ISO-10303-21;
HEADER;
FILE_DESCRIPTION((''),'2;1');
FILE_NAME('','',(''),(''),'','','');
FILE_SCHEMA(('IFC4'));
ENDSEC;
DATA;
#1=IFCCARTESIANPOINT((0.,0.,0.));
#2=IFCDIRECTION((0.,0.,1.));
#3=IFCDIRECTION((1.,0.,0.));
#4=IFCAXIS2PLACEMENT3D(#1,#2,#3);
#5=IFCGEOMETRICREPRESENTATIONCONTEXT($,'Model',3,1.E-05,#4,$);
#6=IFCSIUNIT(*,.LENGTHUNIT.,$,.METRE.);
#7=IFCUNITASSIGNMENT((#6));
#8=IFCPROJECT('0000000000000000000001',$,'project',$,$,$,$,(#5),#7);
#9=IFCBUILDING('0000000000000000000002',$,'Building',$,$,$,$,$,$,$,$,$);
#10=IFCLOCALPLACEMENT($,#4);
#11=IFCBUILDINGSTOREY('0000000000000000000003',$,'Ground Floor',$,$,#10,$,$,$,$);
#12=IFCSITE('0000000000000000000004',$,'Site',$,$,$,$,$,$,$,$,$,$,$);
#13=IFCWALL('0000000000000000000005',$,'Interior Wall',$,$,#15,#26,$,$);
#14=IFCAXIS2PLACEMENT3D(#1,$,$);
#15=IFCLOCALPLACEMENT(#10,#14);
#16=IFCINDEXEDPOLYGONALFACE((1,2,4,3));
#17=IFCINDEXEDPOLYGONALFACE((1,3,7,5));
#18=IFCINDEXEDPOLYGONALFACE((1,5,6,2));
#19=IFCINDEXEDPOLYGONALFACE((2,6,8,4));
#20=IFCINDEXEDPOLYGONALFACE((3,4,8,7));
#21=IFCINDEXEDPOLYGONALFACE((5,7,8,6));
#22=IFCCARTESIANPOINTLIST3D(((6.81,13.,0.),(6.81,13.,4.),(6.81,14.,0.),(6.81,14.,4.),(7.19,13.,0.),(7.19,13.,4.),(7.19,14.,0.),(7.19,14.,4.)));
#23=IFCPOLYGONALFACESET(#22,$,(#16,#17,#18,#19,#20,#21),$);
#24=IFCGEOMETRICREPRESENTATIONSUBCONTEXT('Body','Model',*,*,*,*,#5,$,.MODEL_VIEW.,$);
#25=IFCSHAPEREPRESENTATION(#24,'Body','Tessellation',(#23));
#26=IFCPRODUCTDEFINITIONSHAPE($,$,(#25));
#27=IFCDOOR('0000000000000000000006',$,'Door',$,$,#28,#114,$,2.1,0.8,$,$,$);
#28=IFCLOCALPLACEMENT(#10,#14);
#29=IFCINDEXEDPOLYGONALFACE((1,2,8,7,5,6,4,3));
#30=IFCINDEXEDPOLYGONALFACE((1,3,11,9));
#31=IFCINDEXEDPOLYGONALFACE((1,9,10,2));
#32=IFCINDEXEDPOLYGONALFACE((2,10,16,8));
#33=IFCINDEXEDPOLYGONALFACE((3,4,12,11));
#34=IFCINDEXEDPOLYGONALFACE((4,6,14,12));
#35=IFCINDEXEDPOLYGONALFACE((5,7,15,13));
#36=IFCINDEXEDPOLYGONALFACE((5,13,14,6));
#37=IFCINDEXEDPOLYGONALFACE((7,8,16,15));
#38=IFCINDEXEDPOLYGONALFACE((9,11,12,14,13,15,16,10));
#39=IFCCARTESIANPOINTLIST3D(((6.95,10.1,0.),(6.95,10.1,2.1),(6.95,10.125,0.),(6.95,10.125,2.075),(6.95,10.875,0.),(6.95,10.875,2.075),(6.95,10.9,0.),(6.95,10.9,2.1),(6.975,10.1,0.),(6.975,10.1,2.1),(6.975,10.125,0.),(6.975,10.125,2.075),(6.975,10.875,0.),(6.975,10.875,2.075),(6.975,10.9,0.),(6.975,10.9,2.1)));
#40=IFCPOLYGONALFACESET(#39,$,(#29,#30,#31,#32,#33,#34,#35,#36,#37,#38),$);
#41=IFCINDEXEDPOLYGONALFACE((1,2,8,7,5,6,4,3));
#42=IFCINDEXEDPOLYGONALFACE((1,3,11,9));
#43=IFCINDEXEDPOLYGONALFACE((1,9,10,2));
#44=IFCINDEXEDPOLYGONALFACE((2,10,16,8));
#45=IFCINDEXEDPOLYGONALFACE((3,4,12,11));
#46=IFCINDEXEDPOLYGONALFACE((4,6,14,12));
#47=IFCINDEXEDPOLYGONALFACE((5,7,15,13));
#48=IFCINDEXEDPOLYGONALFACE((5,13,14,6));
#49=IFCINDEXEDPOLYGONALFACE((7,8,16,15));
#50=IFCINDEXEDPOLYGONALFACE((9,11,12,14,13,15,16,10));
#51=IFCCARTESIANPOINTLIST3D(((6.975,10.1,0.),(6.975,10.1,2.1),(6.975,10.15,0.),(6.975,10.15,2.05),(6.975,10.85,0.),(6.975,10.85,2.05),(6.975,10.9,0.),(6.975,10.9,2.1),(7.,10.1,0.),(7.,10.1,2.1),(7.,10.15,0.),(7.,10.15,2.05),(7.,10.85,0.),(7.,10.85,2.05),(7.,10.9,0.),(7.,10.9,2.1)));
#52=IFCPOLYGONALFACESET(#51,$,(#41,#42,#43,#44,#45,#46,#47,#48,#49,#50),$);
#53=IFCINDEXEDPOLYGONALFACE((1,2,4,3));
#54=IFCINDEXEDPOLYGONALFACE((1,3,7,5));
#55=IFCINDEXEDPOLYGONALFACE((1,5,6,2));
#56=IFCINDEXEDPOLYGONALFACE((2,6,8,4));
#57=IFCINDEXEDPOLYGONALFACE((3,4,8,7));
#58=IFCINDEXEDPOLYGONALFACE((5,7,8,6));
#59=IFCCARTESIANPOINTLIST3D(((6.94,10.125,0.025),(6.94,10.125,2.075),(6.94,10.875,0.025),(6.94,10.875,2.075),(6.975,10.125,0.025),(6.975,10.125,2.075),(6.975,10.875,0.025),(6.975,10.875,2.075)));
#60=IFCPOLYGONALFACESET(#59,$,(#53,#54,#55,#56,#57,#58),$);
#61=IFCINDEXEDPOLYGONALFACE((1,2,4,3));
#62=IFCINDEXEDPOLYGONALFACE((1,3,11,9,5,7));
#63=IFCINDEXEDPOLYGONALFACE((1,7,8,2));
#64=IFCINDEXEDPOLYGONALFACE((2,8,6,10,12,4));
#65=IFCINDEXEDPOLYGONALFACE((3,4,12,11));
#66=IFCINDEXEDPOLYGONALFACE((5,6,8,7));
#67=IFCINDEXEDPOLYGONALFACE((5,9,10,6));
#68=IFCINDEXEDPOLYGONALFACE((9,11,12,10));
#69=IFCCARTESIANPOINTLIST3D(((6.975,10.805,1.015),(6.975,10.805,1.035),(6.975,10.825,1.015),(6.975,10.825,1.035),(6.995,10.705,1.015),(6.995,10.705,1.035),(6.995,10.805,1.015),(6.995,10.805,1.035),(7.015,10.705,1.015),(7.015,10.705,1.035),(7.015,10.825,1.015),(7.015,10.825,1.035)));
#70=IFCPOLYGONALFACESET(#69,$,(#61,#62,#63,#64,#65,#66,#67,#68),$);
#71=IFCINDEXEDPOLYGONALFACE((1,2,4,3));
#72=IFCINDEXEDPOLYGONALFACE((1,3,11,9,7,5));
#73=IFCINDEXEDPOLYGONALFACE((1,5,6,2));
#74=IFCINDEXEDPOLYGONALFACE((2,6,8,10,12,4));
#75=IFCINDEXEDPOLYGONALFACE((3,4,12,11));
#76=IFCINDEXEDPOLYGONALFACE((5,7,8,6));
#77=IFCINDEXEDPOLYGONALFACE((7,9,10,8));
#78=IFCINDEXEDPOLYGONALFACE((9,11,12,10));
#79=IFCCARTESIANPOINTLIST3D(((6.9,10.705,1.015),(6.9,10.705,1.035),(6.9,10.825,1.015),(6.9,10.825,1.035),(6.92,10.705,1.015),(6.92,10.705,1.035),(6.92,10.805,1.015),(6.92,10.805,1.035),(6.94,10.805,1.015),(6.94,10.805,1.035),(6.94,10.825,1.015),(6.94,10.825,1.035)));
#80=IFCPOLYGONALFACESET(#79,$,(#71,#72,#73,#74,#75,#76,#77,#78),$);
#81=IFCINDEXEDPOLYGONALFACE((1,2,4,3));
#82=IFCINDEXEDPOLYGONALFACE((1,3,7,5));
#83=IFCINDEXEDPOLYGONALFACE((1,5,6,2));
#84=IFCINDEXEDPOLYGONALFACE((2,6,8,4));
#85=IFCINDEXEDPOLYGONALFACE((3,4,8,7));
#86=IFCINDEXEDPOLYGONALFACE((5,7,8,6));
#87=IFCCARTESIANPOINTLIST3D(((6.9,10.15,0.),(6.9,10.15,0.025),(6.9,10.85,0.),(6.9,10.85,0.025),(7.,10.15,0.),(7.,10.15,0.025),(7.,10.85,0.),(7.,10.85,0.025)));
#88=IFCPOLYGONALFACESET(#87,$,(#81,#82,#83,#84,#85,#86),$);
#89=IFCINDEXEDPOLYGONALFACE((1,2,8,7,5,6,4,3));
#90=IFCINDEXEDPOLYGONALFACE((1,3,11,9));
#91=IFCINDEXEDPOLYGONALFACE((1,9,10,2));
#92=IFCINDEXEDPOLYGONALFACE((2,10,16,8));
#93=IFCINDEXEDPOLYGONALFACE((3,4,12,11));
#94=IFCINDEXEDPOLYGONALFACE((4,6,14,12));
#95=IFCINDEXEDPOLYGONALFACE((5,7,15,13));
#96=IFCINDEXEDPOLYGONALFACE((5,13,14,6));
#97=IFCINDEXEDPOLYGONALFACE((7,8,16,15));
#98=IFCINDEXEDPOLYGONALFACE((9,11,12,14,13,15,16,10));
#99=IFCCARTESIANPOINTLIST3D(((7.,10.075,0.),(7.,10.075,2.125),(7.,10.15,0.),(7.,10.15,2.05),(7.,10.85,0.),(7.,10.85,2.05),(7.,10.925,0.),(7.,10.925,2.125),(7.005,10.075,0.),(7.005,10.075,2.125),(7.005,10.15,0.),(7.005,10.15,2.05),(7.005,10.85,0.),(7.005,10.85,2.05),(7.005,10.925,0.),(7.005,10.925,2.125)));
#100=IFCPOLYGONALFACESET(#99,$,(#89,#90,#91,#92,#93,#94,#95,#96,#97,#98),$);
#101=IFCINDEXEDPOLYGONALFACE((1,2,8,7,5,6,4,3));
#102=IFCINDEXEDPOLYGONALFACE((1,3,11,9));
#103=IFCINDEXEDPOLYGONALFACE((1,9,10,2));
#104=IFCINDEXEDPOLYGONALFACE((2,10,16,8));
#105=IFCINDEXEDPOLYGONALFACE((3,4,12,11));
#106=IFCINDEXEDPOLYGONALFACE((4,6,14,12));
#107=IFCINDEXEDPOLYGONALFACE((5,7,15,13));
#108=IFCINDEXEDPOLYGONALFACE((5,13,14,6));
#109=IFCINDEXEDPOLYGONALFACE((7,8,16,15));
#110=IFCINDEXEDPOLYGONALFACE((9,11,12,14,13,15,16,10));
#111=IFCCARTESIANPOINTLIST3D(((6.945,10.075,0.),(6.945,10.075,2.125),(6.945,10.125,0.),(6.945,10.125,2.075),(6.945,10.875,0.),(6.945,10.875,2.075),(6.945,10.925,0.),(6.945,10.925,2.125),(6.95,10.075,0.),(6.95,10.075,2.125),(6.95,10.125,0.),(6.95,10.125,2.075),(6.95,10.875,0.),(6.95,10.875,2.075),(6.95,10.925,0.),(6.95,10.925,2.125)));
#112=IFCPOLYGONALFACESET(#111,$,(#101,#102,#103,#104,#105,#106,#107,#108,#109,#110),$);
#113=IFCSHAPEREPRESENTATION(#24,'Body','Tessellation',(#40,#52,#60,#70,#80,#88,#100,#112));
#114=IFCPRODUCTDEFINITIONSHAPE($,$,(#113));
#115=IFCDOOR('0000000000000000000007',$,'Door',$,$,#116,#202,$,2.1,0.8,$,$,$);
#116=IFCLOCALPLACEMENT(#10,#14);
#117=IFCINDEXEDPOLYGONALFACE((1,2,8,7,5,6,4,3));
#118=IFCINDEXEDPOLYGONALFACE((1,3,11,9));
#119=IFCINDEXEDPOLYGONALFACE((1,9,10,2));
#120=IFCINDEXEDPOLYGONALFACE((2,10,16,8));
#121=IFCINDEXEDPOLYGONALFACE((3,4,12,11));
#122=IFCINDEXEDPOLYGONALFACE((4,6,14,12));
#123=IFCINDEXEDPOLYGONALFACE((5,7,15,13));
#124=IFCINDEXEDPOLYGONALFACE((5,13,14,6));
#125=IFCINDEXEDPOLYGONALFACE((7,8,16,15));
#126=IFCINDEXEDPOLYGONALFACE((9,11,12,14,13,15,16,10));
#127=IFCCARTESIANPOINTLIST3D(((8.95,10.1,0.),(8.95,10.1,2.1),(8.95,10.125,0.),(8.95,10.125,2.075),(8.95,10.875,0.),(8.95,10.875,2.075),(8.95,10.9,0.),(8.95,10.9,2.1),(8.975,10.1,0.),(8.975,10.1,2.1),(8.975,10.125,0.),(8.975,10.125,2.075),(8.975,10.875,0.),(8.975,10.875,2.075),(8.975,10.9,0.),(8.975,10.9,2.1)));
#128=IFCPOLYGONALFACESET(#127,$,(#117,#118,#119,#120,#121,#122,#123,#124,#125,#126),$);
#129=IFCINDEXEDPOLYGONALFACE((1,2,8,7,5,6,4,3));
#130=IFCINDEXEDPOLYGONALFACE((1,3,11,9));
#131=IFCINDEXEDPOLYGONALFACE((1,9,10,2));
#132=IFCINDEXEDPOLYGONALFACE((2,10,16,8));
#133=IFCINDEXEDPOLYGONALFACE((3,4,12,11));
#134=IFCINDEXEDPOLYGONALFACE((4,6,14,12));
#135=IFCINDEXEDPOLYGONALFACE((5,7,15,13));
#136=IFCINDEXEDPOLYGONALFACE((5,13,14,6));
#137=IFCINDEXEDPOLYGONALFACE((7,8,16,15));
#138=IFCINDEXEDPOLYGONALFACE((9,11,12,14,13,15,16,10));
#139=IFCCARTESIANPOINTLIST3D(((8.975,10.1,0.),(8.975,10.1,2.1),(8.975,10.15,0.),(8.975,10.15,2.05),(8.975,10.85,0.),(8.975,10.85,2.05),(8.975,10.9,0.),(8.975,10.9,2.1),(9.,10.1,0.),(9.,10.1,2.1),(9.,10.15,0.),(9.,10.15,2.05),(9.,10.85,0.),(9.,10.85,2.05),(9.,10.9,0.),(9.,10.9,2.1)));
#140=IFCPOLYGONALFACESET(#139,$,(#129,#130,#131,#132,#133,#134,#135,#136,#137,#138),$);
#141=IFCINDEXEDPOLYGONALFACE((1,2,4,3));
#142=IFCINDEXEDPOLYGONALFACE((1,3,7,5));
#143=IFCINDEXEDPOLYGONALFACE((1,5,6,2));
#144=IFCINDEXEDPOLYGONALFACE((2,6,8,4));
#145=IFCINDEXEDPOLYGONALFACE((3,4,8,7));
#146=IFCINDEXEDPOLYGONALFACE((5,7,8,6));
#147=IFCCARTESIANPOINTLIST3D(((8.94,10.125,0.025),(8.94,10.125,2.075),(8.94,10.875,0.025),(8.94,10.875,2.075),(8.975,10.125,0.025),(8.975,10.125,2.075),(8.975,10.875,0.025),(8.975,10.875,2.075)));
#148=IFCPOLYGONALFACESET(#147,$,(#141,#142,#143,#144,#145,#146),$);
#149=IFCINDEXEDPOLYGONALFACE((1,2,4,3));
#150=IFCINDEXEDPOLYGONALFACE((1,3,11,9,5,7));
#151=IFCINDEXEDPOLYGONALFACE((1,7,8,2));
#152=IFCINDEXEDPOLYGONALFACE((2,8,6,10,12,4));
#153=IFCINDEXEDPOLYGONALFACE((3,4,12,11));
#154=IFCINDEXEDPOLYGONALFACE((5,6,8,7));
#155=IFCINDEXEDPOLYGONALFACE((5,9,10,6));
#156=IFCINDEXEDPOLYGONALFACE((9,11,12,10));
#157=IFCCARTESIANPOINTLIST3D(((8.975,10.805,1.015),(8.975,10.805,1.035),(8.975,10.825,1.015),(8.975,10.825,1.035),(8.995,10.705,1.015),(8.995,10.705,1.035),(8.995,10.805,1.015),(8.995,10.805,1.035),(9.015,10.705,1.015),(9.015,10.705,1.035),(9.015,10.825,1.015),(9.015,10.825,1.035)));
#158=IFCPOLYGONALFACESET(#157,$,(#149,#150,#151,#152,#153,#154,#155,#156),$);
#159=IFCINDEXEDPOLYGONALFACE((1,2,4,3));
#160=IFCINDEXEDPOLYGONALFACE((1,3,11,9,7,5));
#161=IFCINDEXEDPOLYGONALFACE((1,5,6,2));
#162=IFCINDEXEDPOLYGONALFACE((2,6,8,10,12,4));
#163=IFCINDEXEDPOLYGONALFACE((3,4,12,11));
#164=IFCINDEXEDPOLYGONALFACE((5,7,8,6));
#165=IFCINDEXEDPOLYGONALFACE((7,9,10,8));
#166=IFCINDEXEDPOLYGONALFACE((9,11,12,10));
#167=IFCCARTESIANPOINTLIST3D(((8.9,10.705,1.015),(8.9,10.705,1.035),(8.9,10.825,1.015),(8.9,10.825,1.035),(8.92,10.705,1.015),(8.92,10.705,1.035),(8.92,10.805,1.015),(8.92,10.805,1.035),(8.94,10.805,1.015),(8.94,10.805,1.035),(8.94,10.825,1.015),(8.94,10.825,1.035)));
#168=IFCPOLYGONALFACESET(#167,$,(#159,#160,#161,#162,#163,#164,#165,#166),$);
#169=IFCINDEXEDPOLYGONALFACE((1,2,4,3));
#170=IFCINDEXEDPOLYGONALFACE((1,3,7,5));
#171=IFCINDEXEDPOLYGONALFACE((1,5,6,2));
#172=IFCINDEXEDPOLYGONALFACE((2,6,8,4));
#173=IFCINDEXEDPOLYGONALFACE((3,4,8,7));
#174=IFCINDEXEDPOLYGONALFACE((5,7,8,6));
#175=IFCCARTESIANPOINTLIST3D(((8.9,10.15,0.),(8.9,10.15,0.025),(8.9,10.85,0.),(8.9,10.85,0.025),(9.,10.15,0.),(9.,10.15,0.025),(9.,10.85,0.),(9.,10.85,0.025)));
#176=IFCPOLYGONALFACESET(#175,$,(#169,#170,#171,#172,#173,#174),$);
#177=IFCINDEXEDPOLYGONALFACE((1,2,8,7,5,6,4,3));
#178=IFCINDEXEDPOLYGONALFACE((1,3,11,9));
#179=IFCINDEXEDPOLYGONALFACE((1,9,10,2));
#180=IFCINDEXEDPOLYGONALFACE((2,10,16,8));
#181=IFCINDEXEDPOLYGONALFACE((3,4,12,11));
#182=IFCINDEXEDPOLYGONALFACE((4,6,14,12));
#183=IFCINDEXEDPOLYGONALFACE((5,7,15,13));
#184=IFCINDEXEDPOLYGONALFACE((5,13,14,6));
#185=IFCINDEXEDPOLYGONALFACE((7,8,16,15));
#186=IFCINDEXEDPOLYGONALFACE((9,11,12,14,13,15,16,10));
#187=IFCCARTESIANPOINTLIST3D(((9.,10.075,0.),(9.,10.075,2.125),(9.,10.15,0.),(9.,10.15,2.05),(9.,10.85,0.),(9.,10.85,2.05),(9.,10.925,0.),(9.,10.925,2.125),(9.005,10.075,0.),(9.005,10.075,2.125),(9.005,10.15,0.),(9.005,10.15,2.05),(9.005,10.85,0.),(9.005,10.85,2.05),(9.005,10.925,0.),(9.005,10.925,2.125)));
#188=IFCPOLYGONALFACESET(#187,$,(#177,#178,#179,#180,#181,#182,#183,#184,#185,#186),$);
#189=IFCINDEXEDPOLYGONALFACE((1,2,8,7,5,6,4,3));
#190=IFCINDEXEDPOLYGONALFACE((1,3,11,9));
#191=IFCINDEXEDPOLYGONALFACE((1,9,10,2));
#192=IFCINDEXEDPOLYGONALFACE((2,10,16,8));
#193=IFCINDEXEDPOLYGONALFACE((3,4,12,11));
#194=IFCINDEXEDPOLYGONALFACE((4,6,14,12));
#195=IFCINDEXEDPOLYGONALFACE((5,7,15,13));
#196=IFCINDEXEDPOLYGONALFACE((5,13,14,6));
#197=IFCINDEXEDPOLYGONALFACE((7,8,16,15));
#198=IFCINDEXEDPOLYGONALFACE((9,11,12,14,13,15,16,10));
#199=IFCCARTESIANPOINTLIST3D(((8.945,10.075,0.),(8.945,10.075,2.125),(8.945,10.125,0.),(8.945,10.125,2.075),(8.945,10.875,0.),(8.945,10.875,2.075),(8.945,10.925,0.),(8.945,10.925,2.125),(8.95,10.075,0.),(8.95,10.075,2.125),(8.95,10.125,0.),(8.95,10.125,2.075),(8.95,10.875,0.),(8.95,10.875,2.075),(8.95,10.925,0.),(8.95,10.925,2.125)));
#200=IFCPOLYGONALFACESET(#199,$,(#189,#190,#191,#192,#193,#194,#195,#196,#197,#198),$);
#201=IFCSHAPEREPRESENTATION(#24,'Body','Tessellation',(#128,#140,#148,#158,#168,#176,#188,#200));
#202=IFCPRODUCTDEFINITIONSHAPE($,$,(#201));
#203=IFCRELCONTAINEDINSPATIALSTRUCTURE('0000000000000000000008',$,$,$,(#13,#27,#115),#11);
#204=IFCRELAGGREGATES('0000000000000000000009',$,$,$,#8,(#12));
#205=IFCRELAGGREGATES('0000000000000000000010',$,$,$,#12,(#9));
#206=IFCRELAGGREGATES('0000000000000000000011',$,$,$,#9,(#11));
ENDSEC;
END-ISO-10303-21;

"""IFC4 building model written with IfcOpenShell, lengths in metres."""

from ifc_helpers import new_model, si_unit, frame, origin_with_axes, place, context, subcontext, project, spatial, line, indexed_curve, outline, extrude, element, save


model = new_model("IFC4")

# Units and contexts
model_context = context("Model", 3, precision=1e-05, world=origin_with_axes())
body_context = subcontext(model_context, "Body", "Model", "MODEL_VIEW")
ifc_project = project(units=[si_unit("LENGTHUNIT", "METRE")], contexts=[model_context])

# Site, building, storey
site = spatial("IfcSite", under=ifc_project, Name="Site")
building = spatial("IfcBuilding", under=site, Name="Building")
storey_placement = place(None, origin_with_axes())
storey = spatial("IfcBuildingStorey", under=building, at=storey_placement, Name="Ground Floor")

# Wall
wall_1_placement = place(storey_placement, frame((7.0, 14.0, 0.0), z_axis=(0.0, 0.0, 1.0), x_axis=(0.0, -1.0, 0.0)))
element("IfcWall", 1, at=wall_1_placement, inside=storey, Name="Interior Wall", context=body_context, shape_type="SweptSolid", body=[
    extrude(outline(indexed_curve([(0.0, 0.0), (0.0, 0.38), (1.0, 0.38), (1.0, 0.0), (0.0, 0.0)], self_intersect=False)), frame((0.0, -0.19, 0.0), z_axis=(0.0, 0.0, 1.0), x_axis=(1.0, 0.0, 0.0)), (0.0, 0.0, 1.0), 4.0),
])

# Doors
door_1_placement = place(storey_placement, frame((7.0, 10.1, 0.0), z_axis=(0.0, 0.0, 1.0), x_axis=(0.0, 1.0, 0.0)))
element("IfcDoor", 2, at=door_1_placement, inside=storey, Name="Door", OverallHeight=2.1, OverallWidth=0.8, context=body_context, shape_type="SweptSolid", body=[
    extrude(outline(indexed_curve([(0.0, 0.0), (0.0, 2.1), (0.8, 2.1), (0.8, 0.0), (0.775, 0.0), (0.775, 2.075), (0.025, 2.075), (0.025, 0.0)], segments=[line(1, 2, 3, 4, 5, 6, 7, 8, 1)])), frame((0.0, 0.025, 0.0), z_axis=(0.0, -1.0, 0.0), x_axis=(1.0, 0.0, 0.0)), (0.0, 0.0, -1.0), 0.025),
    extrude(outline(indexed_curve([(0.0, 0.0), (0.0, 2.1), (0.8, 2.1), (0.8, 0.0), (0.75, 0.0), (0.75, 2.05), (0.05, 2.05), (0.05, 0.0)], segments=[line(1, 2, 3, 4, 5, 6, 7, 8, 1)])), frame((0.0, 0.0, 0.0), z_axis=(0.0, -1.0, 0.0), x_axis=(1.0, 0.0, 0.0)), (0.0, 0.0, -1.0), 0.025),
    extrude(outline(indexed_curve([(0.0, 0.0), (0.75, 0.0), (0.75, 0.035), (0.0, 0.035)], segments=[line(1, 2, 3, 4, 1)])), frame((0.025, 0.025, 0.025), z_axis=(0.0, 0.0, 1.0), x_axis=(1.0, 0.0, 0.0)), (0.0, 0.0, 1.0), 2.05),
    extrude(outline(indexed_curve([(0.0, 0.0), (0.0, -0.04), (-0.12, -0.04), (-0.12, -0.02), (-0.02, -0.02), (-0.02, 0.0)], segments=[line(1, 2, 3, 4, 5, 6, 1)])), frame((0.725, 0.025, 1.015), z_axis=(0.0, 0.0, 1.0), x_axis=(1.0, 0.0, 0.0)), (0.0, 0.0, 1.0), 0.02),
    extrude(outline(indexed_curve([(0.0, 0.0), (0.0, 0.04), (-0.12, 0.04), (-0.12, 0.02), (-0.02, 0.02), (-0.02, 0.0)], segments=[line(1, 2, 3, 4, 5, 6, 1)])), frame((0.725, 0.06, 1.015), z_axis=(0.0, 0.0, 1.0), x_axis=(1.0, 0.0, 0.0)), (0.0, 0.0, 1.0), 0.02),
    extrude(outline(indexed_curve([(0.0, 0.0), (0.7, 0.0), (0.7, 0.1), (0.0, 0.1)], segments=[line(1, 2, 3, 4, 1)])), frame((0.05, 0.0, 0.0), z_axis=(0.0, 0.0, 1.0), x_axis=(1.0, 0.0, 0.0)), (0.0, 0.0, 1.0), 0.025),
    extrude(outline(indexed_curve([(0.0, 0.0), (0.0, 2.125), (0.85, 2.125), (0.85, 0.0), (0.775, 0.0), (0.775, 2.05), (0.075, 2.05), (0.075, 0.0)], segments=[line(1, 2, 3, 4, 5, 6, 7, 8, 1)])), frame((-0.025, -0.005, 0.0), z_axis=(0.0, -1.0, 0.0), x_axis=(1.0, 0.0, 0.0)), (0.0, 0.0, -1.0), 0.005),
    extrude(outline(indexed_curve([(0.0, 0.0), (0.0, 2.125), (0.85, 2.125), (0.85, 0.0), (0.8, 0.0), (0.8, 2.075), (0.05, 2.075), (0.05, 0.0)], segments=[line(1, 2, 3, 4, 5, 6, 7, 8, 1)])), frame((-0.025, 0.05, 0.0), z_axis=(0.0, -1.0, 0.0), x_axis=(1.0, 0.0, 0.0)), (0.0, 0.0, -1.0), 0.005),
])
door_2_placement = place(storey_placement, frame((9.0, 10.1, 0.0), z_axis=(0.0, 0.0, 1.0), x_axis=(0.0, 1.0, 0.0)))
element("IfcDoor", 3, at=door_2_placement, inside=storey, Name="Door", OverallHeight=2.1, OverallWidth=0.8, context=body_context, shape_type="SweptSolid", body=[
    extrude(outline(indexed_curve([(0.0, 0.0), (0.0, 2.1), (0.8, 2.1), (0.8, 0.0), (0.775, 0.0), (0.775, 2.075), (0.025, 2.075), (0.025, 0.0)], segments=[line(1, 2, 3, 4, 5, 6, 7, 8, 1)])), frame((0.0, 0.025, 0.0), z_axis=(0.0, -1.0, 0.0), x_axis=(1.0, 0.0, 0.0)), (0.0, 0.0, -1.0), 0.025),
    extrude(outline(indexed_curve([(0.0, 0.0), (0.0, 2.1), (0.8, 2.1), (0.8, 0.0), (0.75, 0.0), (0.75, 2.05), (0.05, 2.05), (0.05, 0.0)], segments=[line(1, 2, 3, 4, 5, 6, 7, 8, 1)])), frame((0.0, 0.0, 0.0), z_axis=(0.0, -1.0, 0.0), x_axis=(1.0, 0.0, 0.0)), (0.0, 0.0, -1.0), 0.025),
    extrude(outline(indexed_curve([(0.0, 0.0), (0.75, 0.0), (0.75, 0.035), (0.0, 0.035)], segments=[line(1, 2, 3, 4, 1)])), frame((0.025, 0.025, 0.025), z_axis=(0.0, 0.0, 1.0), x_axis=(1.0, 0.0, 0.0)), (0.0, 0.0, 1.0), 2.05),
    extrude(outline(indexed_curve([(0.0, 0.0), (0.0, -0.04), (-0.12, -0.04), (-0.12, -0.02), (-0.02, -0.02), (-0.02, 0.0)], segments=[line(1, 2, 3, 4, 5, 6, 1)])), frame((0.725, 0.025, 1.015), z_axis=(0.0, 0.0, 1.0), x_axis=(1.0, 0.0, 0.0)), (0.0, 0.0, 1.0), 0.02),
    extrude(outline(indexed_curve([(0.0, 0.0), (0.0, 0.04), (-0.12, 0.04), (-0.12, 0.02), (-0.02, 0.02), (-0.02, 0.0)], segments=[line(1, 2, 3, 4, 5, 6, 1)])), frame((0.725, 0.06, 1.015), z_axis=(0.0, 0.0, 1.0), x_axis=(1.0, 0.0, 0.0)), (0.0, 0.0, 1.0), 0.02),
    extrude(outline(indexed_curve([(0.0, 0.0), (0.7, 0.0), (0.7, 0.1), (0.0, 0.1)], segments=[line(1, 2, 3, 4, 1)])), frame((0.05, 0.0, 0.0), z_axis=(0.0, 0.0, 1.0), x_axis=(1.0, 0.0, 0.0)), (0.0, 0.0, 1.0), 0.025),
    extrude(outline(indexed_curve([(0.0, 0.0), (0.0, 2.125), (0.85, 2.125), (0.85, 0.0), (0.775, 0.0), (0.775, 2.05), (0.075, 2.05), (0.075, 0.0)], segments=[line(1, 2, 3, 4, 5, 6, 7, 8, 1)])), frame((-0.025, -0.005, 0.0), z_axis=(0.0, -1.0, 0.0), x_axis=(1.0, 0.0, 0.0)), (0.0, 0.0, -1.0), 0.005),
    extrude(outline(indexed_curve([(0.0, 0.0), (0.0, 2.125), (0.85, 2.125), (0.85, 0.0), (0.8, 0.0), (0.8, 2.075), (0.05, 2.075), (0.05, 0.0)], segments=[line(1, 2, 3, 4, 5, 6, 7, 8, 1)])), frame((-0.025, 0.05, 0.0), z_axis=(0.0, -1.0, 0.0), x_axis=(1.0, 0.0, 0.0)), (0.0, 0.0, -1.0), 0.005),
])

save(model, "model.ifc")
